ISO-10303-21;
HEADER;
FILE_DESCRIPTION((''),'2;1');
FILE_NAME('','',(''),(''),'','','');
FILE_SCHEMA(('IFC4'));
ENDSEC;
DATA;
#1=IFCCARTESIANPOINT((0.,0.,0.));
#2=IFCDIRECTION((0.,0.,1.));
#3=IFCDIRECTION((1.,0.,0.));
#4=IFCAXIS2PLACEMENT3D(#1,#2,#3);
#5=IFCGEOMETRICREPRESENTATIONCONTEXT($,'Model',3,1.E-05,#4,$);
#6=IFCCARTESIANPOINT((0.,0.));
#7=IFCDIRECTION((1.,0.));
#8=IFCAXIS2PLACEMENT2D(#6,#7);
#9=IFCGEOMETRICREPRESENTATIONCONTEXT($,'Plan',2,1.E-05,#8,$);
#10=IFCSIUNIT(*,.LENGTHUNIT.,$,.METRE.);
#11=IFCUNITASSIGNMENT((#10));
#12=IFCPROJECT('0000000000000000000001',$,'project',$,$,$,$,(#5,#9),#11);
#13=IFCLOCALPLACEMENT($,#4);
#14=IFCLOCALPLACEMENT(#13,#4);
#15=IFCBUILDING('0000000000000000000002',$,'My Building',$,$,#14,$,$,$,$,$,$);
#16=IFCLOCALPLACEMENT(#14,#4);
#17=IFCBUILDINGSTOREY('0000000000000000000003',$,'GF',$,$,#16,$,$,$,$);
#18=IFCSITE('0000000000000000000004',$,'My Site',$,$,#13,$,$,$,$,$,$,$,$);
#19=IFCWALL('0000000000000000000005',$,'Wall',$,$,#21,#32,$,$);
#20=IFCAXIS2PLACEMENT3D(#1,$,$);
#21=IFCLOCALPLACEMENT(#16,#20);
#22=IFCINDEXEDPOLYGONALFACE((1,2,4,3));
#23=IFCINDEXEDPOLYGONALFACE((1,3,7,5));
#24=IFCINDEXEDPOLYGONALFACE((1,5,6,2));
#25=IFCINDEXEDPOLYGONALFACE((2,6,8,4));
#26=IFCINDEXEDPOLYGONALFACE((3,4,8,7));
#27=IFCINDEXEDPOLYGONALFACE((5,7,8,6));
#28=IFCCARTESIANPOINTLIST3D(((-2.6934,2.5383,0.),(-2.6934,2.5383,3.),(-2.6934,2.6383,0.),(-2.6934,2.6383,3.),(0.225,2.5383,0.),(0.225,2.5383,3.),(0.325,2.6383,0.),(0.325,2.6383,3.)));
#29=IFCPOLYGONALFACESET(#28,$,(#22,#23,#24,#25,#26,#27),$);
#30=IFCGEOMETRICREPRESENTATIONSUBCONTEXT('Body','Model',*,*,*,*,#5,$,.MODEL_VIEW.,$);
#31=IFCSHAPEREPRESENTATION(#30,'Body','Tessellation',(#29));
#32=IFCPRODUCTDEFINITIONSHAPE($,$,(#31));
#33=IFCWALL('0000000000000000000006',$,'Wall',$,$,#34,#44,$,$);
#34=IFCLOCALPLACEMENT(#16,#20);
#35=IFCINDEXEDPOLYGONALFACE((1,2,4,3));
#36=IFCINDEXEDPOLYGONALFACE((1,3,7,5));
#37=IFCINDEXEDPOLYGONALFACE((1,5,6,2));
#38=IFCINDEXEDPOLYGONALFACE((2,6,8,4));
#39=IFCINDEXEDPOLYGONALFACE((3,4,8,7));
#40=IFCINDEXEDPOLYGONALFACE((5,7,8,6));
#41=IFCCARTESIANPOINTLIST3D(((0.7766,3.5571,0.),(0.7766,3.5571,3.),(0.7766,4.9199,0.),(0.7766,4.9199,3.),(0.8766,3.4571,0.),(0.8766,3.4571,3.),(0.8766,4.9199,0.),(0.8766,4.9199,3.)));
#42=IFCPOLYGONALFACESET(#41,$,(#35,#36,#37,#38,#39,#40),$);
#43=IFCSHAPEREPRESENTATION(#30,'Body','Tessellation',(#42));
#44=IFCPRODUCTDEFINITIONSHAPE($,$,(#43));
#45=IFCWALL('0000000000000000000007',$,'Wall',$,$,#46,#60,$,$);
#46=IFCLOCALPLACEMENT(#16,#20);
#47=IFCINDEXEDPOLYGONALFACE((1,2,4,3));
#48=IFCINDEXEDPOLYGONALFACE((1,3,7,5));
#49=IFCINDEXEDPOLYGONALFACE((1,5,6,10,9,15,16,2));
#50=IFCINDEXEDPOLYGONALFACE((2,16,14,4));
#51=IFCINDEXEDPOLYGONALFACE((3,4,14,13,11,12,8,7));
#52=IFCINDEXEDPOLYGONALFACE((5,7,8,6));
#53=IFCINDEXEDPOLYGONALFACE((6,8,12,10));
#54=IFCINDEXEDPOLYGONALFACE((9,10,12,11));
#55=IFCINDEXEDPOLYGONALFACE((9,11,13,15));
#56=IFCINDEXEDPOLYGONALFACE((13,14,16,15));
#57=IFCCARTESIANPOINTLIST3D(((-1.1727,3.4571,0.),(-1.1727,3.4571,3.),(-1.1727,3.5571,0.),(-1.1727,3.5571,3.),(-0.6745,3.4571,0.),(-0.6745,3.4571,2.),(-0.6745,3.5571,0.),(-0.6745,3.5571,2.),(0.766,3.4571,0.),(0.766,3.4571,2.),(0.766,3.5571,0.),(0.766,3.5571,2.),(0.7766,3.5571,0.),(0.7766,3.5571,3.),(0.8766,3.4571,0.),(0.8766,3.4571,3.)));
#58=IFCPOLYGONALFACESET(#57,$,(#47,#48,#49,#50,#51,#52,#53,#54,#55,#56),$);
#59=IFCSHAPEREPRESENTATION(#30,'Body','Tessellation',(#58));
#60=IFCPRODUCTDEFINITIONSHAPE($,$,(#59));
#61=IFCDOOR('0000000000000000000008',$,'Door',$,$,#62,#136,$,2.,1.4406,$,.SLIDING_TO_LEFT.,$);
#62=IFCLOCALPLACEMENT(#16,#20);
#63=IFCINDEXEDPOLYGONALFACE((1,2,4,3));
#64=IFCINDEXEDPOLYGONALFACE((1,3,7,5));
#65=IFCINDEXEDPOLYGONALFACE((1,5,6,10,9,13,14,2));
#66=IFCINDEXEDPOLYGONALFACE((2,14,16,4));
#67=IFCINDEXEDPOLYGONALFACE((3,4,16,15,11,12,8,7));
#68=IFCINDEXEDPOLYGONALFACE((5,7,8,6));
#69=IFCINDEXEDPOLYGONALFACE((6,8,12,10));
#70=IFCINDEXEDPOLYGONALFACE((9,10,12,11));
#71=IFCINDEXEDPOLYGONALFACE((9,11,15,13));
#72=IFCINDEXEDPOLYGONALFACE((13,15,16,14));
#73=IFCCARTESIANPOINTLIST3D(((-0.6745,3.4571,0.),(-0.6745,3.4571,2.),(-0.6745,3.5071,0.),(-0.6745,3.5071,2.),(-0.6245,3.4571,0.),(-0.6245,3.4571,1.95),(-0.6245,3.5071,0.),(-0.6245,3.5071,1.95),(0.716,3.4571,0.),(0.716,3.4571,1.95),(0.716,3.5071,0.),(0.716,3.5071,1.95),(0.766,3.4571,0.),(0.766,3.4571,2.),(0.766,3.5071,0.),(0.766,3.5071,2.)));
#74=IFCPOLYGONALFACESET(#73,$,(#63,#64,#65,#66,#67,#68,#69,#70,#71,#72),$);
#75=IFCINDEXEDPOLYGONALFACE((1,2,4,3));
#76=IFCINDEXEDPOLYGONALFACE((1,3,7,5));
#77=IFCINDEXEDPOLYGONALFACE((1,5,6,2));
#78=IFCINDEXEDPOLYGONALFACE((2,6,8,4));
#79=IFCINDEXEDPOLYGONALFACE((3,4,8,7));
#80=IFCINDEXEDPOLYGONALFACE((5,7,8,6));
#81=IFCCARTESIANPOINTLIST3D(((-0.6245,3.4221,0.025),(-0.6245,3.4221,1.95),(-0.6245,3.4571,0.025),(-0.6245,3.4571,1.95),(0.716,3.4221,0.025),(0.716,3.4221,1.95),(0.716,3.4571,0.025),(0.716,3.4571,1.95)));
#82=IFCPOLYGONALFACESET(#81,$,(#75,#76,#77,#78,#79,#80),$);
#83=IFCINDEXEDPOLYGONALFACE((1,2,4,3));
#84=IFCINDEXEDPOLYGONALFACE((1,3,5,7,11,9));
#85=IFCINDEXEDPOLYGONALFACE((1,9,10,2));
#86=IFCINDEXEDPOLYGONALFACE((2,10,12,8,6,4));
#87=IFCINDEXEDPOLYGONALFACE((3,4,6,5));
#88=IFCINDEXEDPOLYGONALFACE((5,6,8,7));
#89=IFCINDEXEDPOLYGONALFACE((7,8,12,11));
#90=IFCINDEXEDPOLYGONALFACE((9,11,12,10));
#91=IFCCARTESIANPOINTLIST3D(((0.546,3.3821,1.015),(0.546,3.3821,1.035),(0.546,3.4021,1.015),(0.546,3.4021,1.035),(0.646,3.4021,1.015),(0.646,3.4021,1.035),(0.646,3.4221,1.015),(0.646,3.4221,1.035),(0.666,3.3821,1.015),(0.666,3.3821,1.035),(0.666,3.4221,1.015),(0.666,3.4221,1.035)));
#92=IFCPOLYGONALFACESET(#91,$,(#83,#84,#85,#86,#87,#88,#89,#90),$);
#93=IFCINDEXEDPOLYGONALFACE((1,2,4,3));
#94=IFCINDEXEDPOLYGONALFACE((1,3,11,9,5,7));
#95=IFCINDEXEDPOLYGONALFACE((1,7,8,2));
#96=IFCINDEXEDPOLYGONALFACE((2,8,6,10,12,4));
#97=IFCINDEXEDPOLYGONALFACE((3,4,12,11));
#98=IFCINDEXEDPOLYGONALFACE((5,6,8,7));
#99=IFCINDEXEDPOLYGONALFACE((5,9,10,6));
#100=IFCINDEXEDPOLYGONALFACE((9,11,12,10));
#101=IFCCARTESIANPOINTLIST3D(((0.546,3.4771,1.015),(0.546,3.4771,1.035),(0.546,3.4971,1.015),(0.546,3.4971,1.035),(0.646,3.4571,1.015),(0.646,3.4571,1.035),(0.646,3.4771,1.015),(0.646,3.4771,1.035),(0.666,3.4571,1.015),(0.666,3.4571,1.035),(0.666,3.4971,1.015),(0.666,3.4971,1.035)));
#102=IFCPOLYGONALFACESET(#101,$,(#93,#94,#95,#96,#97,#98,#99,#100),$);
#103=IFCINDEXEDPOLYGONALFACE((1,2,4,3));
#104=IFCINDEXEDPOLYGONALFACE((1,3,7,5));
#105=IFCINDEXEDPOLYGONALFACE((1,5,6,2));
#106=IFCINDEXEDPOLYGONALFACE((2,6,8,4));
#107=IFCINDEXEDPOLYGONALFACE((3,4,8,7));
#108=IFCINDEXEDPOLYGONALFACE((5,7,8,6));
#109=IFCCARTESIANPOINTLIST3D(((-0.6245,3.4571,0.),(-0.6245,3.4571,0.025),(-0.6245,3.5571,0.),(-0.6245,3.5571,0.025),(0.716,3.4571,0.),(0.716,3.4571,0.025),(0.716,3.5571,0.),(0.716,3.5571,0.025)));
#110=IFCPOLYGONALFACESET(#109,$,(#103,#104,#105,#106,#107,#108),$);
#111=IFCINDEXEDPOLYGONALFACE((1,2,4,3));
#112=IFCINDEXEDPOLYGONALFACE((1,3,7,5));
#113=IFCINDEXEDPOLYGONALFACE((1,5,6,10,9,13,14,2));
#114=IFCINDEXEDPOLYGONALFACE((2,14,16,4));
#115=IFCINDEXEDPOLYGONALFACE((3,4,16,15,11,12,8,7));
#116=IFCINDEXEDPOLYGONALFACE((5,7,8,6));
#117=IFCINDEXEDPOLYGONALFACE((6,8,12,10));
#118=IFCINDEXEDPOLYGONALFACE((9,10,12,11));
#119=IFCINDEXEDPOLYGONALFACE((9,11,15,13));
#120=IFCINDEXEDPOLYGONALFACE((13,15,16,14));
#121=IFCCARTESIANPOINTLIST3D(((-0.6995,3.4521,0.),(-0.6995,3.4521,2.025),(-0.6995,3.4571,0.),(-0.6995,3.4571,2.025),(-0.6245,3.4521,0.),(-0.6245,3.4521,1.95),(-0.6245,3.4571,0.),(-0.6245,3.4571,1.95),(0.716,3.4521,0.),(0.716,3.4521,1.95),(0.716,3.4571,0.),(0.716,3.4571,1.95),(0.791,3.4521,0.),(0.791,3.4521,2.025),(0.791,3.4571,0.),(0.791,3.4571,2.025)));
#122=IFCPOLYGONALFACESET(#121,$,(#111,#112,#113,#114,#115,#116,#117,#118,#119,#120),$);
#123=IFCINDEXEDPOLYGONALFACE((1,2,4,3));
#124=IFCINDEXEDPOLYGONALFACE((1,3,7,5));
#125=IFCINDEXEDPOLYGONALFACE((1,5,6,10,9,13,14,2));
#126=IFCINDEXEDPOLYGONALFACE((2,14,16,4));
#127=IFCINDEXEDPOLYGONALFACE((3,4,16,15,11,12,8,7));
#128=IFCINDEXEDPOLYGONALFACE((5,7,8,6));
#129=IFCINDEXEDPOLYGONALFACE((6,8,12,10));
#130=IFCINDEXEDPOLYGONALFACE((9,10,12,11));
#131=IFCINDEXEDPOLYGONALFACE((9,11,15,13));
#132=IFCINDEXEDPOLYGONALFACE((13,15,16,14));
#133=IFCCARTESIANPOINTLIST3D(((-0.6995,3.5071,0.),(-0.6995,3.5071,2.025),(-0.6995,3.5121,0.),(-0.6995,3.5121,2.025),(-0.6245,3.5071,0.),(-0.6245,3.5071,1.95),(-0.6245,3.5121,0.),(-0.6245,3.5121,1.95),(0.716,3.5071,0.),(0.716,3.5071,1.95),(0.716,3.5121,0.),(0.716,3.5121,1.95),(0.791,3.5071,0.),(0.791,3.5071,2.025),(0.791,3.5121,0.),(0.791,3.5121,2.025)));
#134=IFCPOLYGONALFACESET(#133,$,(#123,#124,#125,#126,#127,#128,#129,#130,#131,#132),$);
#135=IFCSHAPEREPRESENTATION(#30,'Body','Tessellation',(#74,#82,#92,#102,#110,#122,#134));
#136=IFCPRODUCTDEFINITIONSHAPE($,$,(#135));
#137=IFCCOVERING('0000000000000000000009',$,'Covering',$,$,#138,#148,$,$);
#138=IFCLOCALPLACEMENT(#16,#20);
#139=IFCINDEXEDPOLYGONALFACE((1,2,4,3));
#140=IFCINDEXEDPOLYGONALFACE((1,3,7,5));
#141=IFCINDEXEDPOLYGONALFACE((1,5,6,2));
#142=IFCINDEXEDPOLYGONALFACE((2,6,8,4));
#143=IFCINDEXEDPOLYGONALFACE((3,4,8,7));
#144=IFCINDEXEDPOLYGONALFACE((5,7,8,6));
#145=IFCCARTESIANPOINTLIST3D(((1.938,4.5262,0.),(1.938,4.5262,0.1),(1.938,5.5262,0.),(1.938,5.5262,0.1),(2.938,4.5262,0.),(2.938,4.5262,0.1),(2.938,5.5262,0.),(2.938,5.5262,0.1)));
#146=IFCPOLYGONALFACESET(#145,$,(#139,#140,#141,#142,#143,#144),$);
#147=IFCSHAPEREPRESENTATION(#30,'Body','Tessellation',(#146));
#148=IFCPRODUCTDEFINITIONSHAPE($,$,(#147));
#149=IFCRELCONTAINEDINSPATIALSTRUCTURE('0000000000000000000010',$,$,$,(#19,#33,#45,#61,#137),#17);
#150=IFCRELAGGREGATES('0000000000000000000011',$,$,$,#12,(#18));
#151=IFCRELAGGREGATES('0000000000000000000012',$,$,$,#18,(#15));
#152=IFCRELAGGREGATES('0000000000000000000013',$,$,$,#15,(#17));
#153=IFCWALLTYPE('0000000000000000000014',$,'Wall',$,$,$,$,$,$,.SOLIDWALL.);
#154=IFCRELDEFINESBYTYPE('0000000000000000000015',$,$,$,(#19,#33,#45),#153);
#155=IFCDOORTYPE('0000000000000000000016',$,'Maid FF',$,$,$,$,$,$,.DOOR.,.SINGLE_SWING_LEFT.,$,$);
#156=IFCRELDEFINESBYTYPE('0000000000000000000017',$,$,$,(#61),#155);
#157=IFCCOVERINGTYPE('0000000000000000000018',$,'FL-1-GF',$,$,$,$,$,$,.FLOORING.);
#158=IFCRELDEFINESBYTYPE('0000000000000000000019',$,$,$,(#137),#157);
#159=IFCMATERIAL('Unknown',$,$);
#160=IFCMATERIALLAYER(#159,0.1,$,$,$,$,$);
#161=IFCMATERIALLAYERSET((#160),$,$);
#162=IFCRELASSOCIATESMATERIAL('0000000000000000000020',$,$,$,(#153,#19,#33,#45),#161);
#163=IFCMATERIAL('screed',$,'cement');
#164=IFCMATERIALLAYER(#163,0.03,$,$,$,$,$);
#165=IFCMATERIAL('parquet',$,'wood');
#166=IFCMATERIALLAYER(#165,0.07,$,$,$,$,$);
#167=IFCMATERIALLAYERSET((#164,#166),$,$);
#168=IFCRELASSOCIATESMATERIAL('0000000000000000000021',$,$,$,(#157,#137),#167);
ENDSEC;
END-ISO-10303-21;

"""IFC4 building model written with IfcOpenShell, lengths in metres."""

from ifc_helpers import new_model, entity, si_unit, frame, origin_with_axes, origin_2d_with_axis, place, context, subcontext, project, spatial, line, indexed_curve, outline, extrude, shape, source, transform, mapped, material, layer, layer_set, layer_usage, type_object, type_shapes, element, fill, save


model = new_model("IFC4")

# Units and contexts
model_context = context("Model", 3, precision=1e-05, world=origin_with_axes())
plan_context = context("Plan", 2, precision=1e-05, world=origin_2d_with_axis())
body_context_1 = subcontext(model_context, "Body", "Model", "MODEL_VIEW")
body_context_2 = subcontext(plan_context, "Body", "Plan", "PLAN_VIEW")
ifc_project = project(units=[si_unit("LENGTHUNIT", "METRE")], contexts=[model_context, plan_context])

# Site, building, storey
site_placement = place(None, origin_with_axes())
site = spatial("IfcSite", under=ifc_project, at=site_placement, Name="My Site")
building_placement = place(site_placement, origin_with_axes())
building = spatial("IfcBuilding", under=site, at=building_placement, Name="My Building")
storey_placement = place(building_placement, origin_with_axes())
storey = spatial("IfcBuildingStorey", under=building, at=storey_placement, Name="GF")

# Shared definitions
ifc_material_1 = material(Name="Unknown")

# Shared definitions
ifc_layer_1 = layer(ifc_material_1, 0.1)
ifc_layer_set_1 = layer_set([ifc_layer_1])
wall_type = type_object("IfcWallType", Name="Wall", PredefinedType="SOLIDWALL", material=ifc_layer_set_1)

# Walls
ifc_layer_usage_1 = layer_usage(ifc_layer_set_1, "AXIS2", "POSITIVE", 0.0)
wall_1_placement = place(storey_placement, frame((0.325, 2.6383, 0.0), z_axis=(0.0, 0.0, 1.0), x_axis=(-1.0, 0.0, 0.0)))
element("IfcWall", 1, at=wall_1_placement, inside=storey, type_object=wall_type, material=ifc_layer_usage_1, Name="Wall", context=body_context_1, shape_type="SweptSolid", body=[
    extrude(outline(indexed_curve([(0.0, 0.0), (0.1, 0.1), (3.0184, 0.1), (3.0184, 0.0)], segments=[line(1, 2, 3, 4, 1)])), origin_with_axes(), (0.0, 0.0, 1.0), 3.0),
])
ifc_layer_usage_2 = layer_usage(ifc_layer_set_1, "AXIS2", "POSITIVE", 0.0)
wall_2_placement = place(storey_placement, frame((0.7766, 5.0199, 0.0), z_axis=(0.0, 0.0, 1.0), x_axis=(0.0, -1.0, 0.0)))
element("IfcWall", 2, at=wall_2_placement, inside=storey, type_object=wall_type, material=ifc_layer_usage_2, Name="Wall", context=body_context_1, shape_type="SweptSolid", body=[
    extrude(outline(indexed_curve([(0.1, 0.0), (0.1, 0.1), (1.5628, 0.1), (1.4628, 0.0)], segments=[line(1, 2, 3, 4, 1)])), origin_with_axes(), (0.0, 0.0, 1.0), 3.0),
])

# Wall, opening, door
ifc_layer_usage_3 = layer_usage(ifc_layer_set_1, "AXIS2", "POSITIVE", 0.0)
wall_3_placement = place(storey_placement, frame((0.7766, 3.5571, 0.0), z_axis=(0.0, 0.0, 1.0), x_axis=(-1.0, 0.0, 0.0)))
wall_3 = element("IfcWall", 3, at=wall_3_placement, inside=storey, type_object=wall_type, material=ifc_layer_usage_3, Name="Wall", context=body_context_1, shape_type="SweptSolid", body=[
    extrude(outline(indexed_curve([(0.0, 0.0), (-0.1, 0.1), (1.9493, 0.1), (1.9493, 0.0)], segments=[line(1, 2, 3, 4, 1)])), origin_with_axes(), (0.0, 0.0, 1.0), 3.0),
])
shared_shape_1 = source(origin_with_axes(), body_context_1, "Body", "SweptSolid", [
    extrude(outline(indexed_curve([(0.0, 0.0), (1.4406, 0.0), (1.4406, 2.0), (0.0, 2.0)], segments=[line(1, 2, 3, 4, 1)])), frame((0.0, -0.6, 0.0), z_axis=(0.0, -1.0, 0.0), x_axis=(1.0, 0.0, 0.0)), (0.0, 0.0, -1.0), 1.2),
])
opening_1_placement = place(wall_3_placement, frame((1.4511, 0.1, 0.0), z_axis=(0.0, 0.0, 1.0), x_axis=(-1.0, 0.000001, 0.0)))
opening_1 = element("IfcOpeningElement", 4, at=opening_1_placement, cuts=wall_3, PredefinedType="OPENING", context=body_context_1, shape_type="MappedRepresentation", body=[
    mapped(shared_shape_1, transform((0.0, 0.0, 0.0), x_axis=(1.0, 0.0, 0.0), y_axis=(0.0, 1.0, 0.0), z_axis=(0.0, 0.0, 1.0), scale=1.0)),
])
door_type = type_object("IfcDoorType", Name="Maid FF", OperationType="SINGLE_SWING_LEFT", PredefinedType="DOOR")
shared_shape_2 = source(origin_with_axes(), body_context_1, "Body", "SweptSolid", [
    extrude(outline(indexed_curve([(0.0, 0.0), (0.0, 2.0), (1.4406, 2.0), (1.4406, 0.0), (1.3906, 0.0), (1.3906, 1.95), (0.05, 1.95), (0.05, 0.0)], segments=[line(1, 2, 3, 4, 5, 6, 7, 8, 1)])), frame((0.0, 0.0, 0.0), z_axis=(0.0, -1.0, 0.0), x_axis=(1.0, 0.0, 0.0)), (0.0, 0.0, -1.0), 0.05),
    extrude(outline(indexed_curve([(0.0, 0.0), (1.3406, 0.0), (1.3406, 0.035), (0.0, 0.035)], segments=[line(1, 2, 3, 4, 1)])), frame((0.05, -0.035, 0.025), z_axis=(0.0, 0.0, 1.0), x_axis=(1.0, 0.0, 0.0)), (0.0, 0.0, 1.0), 1.925),
    extrude(outline(indexed_curve([(0.0, 0.0), (0.0, -0.04), (-0.12, -0.04), (-0.12, -0.02), (-0.02, -0.02), (-0.02, 0.0)], segments=[line(1, 2, 3, 4, 5, 6, 1)])), frame((1.3406, -0.035, 1.015), z_axis=(0.0, 0.0, 1.0), x_axis=(1.0, 0.0, 0.0)), (0.0, 0.0, 1.0), 0.02),
    extrude(outline(indexed_curve([(0.0, 0.0), (0.0, 0.04), (-0.12, 0.04), (-0.12, 0.02), (-0.02, 0.02), (-0.02, 0.0)], segments=[line(1, 2, 3, 4, 5, 6, 1)])), frame((1.3406, 0.0, 1.015), z_axis=(0.0, 0.0, 1.0), x_axis=(1.0, 0.0, 0.0)), (0.0, 0.0, 1.0), 0.02),
    extrude(outline(indexed_curve([(0.0, 0.0), (1.3406, 0.0), (1.3406, 0.1), (0.0, 0.1)], segments=[line(1, 2, 3, 4, 1)])), frame((0.05, 0.0, 0.0), z_axis=(0.0, 0.0, 1.0), x_axis=(1.0, 0.0, 0.0)), (0.0, 0.0, 1.0), 0.025),
    extrude(outline(indexed_curve([(0.0, 0.0), (0.0, 2.025), (1.4906, 2.025), (1.4906, 0.0), (1.4156, 0.0), (1.4156, 1.95), (0.075, 1.95), (0.075, 0.0)], segments=[line(1, 2, 3, 4, 5, 6, 7, 8, 1)])), frame((-0.025, -0.005, 0.0), z_axis=(0.0, -1.0, 0.0), x_axis=(1.0, 0.0, 0.0)), (0.0, 0.0, -1.0), 0.005),
    extrude(outline(indexed_curve([(0.0, 0.0), (0.0, 2.025), (1.4906, 2.025), (1.4906, 0.0), (1.4156, 0.0), (1.4156, 1.95), (0.075, 1.95), (0.075, 0.0)], segments=[line(1, 2, 3, 4, 5, 6, 7, 8, 1)])), frame((-0.025, 0.05, 0.0), z_axis=(0.0, -1.0, 0.0), x_axis=(1.0, 0.0, 0.0)), (0.0, 0.0, -1.0), 0.005),
])
shared_shape_3 = source(origin_with_axes(), body_context_2, "Body", "Curve2D", [
    entity("IfcIndexedPolyCurve", entity("IfcCartesianPointList2D", [[0.0, 0.0], [0.05, 0.0], [0.05, 0.05], [0.0, 0.05]]), [entity("IfcLineIndex", [1, 2, 3, 4, 1])]),
    entity("IfcIndexedPolyCurve", entity("IfcCartesianPointList2D", [[1.4406, 0.0], [1.3906, 0.0], [1.3906, 0.05], [1.4406, 0.05]]), [entity("IfcLineIndex", [1, 2, 3, 4, 1])]),
    entity("IfcIndexedPolyCurve", entity("IfcCartesianPointList2D", [[-0.6203, -0.035], [0.7203, -0.035], [0.7203, 0.0], [-0.6203, 0.0]]), [entity("IfcLineIndex", [1, 2, 3, 4, 1])]),
])
type_shapes(door_type, [shared_shape_2, shared_shape_3])
door_placement = place(opening_1_placement, frame((0.0, 0.0, 0.0), z_axis=(0.0, 0.0, 1.0), x_axis=(1.0, 0.0, 0.0)))
door = element("IfcDoor", 5, at=door_placement, inside=storey, type_object=door_type, Name="Door", OperationType="SLIDING_TO_LEFT", OverallHeight=2.0, OverallWidth=1.4406, shapes=[
    shape(body_context_1, "Body", "MappedRepresentation", [mapped(shared_shape_2, transform((0.0, 0.0, 0.0), x_axis=(1.0, 0.0, 0.0), y_axis=(0.0, 1.0, 0.0), z_axis=(0.0, 0.0, 1.0), scale=1.0))]),
    shape(body_context_2, "Body", "MappedRepresentation", [mapped(shared_shape_3, transform((0.0, 0.0, 0.0), x_axis=(1.0, 0.0, 0.0), y_axis=(0.0, 1.0, 0.0), z_axis=(0.0, 0.0, 1.0), scale=1.0))]),
])
fill(opening_1, door)

# Covering
ifc_material_2 = material(Name="screed", Category="cement")
ifc_layer_2 = layer(ifc_material_2, 0.03)
ifc_material_3 = material(Name="parquet", Category="wood")
ifc_layer_3 = layer(ifc_material_3, 0.07)
ifc_layer_set_2 = layer_set([ifc_layer_2, ifc_layer_3])
ifc_layer_usage_4 = layer_usage(ifc_layer_set_2, "AXIS3", "POSITIVE", 0.0)
covering_type = type_object("IfcCoveringType", Name="FL-1-GF", PredefinedType="FLOORING", material=ifc_layer_set_2)
covering_placement = place(storey_placement, frame((1.938, 4.5262, 0.0), z_axis=(0.0, 0.0, 1.0), x_axis=(1.0, 0.0, 0.0)))
element("IfcCovering", 6, at=covering_placement, inside=storey, type_object=covering_type, material=ifc_layer_usage_4, Name="Covering", context=body_context_1, shape_type="SweptSolid", body=[
    extrude(outline(indexed_curve([(0.0, 0.0), (1.0, 0.0), (1.0, 1.0), (0.0, 1.0), (0.0, 0.0)])), origin_with_axes(), (0.0, 0.0, 1.0), 0.1),
])

save(model, "model.ifc")
